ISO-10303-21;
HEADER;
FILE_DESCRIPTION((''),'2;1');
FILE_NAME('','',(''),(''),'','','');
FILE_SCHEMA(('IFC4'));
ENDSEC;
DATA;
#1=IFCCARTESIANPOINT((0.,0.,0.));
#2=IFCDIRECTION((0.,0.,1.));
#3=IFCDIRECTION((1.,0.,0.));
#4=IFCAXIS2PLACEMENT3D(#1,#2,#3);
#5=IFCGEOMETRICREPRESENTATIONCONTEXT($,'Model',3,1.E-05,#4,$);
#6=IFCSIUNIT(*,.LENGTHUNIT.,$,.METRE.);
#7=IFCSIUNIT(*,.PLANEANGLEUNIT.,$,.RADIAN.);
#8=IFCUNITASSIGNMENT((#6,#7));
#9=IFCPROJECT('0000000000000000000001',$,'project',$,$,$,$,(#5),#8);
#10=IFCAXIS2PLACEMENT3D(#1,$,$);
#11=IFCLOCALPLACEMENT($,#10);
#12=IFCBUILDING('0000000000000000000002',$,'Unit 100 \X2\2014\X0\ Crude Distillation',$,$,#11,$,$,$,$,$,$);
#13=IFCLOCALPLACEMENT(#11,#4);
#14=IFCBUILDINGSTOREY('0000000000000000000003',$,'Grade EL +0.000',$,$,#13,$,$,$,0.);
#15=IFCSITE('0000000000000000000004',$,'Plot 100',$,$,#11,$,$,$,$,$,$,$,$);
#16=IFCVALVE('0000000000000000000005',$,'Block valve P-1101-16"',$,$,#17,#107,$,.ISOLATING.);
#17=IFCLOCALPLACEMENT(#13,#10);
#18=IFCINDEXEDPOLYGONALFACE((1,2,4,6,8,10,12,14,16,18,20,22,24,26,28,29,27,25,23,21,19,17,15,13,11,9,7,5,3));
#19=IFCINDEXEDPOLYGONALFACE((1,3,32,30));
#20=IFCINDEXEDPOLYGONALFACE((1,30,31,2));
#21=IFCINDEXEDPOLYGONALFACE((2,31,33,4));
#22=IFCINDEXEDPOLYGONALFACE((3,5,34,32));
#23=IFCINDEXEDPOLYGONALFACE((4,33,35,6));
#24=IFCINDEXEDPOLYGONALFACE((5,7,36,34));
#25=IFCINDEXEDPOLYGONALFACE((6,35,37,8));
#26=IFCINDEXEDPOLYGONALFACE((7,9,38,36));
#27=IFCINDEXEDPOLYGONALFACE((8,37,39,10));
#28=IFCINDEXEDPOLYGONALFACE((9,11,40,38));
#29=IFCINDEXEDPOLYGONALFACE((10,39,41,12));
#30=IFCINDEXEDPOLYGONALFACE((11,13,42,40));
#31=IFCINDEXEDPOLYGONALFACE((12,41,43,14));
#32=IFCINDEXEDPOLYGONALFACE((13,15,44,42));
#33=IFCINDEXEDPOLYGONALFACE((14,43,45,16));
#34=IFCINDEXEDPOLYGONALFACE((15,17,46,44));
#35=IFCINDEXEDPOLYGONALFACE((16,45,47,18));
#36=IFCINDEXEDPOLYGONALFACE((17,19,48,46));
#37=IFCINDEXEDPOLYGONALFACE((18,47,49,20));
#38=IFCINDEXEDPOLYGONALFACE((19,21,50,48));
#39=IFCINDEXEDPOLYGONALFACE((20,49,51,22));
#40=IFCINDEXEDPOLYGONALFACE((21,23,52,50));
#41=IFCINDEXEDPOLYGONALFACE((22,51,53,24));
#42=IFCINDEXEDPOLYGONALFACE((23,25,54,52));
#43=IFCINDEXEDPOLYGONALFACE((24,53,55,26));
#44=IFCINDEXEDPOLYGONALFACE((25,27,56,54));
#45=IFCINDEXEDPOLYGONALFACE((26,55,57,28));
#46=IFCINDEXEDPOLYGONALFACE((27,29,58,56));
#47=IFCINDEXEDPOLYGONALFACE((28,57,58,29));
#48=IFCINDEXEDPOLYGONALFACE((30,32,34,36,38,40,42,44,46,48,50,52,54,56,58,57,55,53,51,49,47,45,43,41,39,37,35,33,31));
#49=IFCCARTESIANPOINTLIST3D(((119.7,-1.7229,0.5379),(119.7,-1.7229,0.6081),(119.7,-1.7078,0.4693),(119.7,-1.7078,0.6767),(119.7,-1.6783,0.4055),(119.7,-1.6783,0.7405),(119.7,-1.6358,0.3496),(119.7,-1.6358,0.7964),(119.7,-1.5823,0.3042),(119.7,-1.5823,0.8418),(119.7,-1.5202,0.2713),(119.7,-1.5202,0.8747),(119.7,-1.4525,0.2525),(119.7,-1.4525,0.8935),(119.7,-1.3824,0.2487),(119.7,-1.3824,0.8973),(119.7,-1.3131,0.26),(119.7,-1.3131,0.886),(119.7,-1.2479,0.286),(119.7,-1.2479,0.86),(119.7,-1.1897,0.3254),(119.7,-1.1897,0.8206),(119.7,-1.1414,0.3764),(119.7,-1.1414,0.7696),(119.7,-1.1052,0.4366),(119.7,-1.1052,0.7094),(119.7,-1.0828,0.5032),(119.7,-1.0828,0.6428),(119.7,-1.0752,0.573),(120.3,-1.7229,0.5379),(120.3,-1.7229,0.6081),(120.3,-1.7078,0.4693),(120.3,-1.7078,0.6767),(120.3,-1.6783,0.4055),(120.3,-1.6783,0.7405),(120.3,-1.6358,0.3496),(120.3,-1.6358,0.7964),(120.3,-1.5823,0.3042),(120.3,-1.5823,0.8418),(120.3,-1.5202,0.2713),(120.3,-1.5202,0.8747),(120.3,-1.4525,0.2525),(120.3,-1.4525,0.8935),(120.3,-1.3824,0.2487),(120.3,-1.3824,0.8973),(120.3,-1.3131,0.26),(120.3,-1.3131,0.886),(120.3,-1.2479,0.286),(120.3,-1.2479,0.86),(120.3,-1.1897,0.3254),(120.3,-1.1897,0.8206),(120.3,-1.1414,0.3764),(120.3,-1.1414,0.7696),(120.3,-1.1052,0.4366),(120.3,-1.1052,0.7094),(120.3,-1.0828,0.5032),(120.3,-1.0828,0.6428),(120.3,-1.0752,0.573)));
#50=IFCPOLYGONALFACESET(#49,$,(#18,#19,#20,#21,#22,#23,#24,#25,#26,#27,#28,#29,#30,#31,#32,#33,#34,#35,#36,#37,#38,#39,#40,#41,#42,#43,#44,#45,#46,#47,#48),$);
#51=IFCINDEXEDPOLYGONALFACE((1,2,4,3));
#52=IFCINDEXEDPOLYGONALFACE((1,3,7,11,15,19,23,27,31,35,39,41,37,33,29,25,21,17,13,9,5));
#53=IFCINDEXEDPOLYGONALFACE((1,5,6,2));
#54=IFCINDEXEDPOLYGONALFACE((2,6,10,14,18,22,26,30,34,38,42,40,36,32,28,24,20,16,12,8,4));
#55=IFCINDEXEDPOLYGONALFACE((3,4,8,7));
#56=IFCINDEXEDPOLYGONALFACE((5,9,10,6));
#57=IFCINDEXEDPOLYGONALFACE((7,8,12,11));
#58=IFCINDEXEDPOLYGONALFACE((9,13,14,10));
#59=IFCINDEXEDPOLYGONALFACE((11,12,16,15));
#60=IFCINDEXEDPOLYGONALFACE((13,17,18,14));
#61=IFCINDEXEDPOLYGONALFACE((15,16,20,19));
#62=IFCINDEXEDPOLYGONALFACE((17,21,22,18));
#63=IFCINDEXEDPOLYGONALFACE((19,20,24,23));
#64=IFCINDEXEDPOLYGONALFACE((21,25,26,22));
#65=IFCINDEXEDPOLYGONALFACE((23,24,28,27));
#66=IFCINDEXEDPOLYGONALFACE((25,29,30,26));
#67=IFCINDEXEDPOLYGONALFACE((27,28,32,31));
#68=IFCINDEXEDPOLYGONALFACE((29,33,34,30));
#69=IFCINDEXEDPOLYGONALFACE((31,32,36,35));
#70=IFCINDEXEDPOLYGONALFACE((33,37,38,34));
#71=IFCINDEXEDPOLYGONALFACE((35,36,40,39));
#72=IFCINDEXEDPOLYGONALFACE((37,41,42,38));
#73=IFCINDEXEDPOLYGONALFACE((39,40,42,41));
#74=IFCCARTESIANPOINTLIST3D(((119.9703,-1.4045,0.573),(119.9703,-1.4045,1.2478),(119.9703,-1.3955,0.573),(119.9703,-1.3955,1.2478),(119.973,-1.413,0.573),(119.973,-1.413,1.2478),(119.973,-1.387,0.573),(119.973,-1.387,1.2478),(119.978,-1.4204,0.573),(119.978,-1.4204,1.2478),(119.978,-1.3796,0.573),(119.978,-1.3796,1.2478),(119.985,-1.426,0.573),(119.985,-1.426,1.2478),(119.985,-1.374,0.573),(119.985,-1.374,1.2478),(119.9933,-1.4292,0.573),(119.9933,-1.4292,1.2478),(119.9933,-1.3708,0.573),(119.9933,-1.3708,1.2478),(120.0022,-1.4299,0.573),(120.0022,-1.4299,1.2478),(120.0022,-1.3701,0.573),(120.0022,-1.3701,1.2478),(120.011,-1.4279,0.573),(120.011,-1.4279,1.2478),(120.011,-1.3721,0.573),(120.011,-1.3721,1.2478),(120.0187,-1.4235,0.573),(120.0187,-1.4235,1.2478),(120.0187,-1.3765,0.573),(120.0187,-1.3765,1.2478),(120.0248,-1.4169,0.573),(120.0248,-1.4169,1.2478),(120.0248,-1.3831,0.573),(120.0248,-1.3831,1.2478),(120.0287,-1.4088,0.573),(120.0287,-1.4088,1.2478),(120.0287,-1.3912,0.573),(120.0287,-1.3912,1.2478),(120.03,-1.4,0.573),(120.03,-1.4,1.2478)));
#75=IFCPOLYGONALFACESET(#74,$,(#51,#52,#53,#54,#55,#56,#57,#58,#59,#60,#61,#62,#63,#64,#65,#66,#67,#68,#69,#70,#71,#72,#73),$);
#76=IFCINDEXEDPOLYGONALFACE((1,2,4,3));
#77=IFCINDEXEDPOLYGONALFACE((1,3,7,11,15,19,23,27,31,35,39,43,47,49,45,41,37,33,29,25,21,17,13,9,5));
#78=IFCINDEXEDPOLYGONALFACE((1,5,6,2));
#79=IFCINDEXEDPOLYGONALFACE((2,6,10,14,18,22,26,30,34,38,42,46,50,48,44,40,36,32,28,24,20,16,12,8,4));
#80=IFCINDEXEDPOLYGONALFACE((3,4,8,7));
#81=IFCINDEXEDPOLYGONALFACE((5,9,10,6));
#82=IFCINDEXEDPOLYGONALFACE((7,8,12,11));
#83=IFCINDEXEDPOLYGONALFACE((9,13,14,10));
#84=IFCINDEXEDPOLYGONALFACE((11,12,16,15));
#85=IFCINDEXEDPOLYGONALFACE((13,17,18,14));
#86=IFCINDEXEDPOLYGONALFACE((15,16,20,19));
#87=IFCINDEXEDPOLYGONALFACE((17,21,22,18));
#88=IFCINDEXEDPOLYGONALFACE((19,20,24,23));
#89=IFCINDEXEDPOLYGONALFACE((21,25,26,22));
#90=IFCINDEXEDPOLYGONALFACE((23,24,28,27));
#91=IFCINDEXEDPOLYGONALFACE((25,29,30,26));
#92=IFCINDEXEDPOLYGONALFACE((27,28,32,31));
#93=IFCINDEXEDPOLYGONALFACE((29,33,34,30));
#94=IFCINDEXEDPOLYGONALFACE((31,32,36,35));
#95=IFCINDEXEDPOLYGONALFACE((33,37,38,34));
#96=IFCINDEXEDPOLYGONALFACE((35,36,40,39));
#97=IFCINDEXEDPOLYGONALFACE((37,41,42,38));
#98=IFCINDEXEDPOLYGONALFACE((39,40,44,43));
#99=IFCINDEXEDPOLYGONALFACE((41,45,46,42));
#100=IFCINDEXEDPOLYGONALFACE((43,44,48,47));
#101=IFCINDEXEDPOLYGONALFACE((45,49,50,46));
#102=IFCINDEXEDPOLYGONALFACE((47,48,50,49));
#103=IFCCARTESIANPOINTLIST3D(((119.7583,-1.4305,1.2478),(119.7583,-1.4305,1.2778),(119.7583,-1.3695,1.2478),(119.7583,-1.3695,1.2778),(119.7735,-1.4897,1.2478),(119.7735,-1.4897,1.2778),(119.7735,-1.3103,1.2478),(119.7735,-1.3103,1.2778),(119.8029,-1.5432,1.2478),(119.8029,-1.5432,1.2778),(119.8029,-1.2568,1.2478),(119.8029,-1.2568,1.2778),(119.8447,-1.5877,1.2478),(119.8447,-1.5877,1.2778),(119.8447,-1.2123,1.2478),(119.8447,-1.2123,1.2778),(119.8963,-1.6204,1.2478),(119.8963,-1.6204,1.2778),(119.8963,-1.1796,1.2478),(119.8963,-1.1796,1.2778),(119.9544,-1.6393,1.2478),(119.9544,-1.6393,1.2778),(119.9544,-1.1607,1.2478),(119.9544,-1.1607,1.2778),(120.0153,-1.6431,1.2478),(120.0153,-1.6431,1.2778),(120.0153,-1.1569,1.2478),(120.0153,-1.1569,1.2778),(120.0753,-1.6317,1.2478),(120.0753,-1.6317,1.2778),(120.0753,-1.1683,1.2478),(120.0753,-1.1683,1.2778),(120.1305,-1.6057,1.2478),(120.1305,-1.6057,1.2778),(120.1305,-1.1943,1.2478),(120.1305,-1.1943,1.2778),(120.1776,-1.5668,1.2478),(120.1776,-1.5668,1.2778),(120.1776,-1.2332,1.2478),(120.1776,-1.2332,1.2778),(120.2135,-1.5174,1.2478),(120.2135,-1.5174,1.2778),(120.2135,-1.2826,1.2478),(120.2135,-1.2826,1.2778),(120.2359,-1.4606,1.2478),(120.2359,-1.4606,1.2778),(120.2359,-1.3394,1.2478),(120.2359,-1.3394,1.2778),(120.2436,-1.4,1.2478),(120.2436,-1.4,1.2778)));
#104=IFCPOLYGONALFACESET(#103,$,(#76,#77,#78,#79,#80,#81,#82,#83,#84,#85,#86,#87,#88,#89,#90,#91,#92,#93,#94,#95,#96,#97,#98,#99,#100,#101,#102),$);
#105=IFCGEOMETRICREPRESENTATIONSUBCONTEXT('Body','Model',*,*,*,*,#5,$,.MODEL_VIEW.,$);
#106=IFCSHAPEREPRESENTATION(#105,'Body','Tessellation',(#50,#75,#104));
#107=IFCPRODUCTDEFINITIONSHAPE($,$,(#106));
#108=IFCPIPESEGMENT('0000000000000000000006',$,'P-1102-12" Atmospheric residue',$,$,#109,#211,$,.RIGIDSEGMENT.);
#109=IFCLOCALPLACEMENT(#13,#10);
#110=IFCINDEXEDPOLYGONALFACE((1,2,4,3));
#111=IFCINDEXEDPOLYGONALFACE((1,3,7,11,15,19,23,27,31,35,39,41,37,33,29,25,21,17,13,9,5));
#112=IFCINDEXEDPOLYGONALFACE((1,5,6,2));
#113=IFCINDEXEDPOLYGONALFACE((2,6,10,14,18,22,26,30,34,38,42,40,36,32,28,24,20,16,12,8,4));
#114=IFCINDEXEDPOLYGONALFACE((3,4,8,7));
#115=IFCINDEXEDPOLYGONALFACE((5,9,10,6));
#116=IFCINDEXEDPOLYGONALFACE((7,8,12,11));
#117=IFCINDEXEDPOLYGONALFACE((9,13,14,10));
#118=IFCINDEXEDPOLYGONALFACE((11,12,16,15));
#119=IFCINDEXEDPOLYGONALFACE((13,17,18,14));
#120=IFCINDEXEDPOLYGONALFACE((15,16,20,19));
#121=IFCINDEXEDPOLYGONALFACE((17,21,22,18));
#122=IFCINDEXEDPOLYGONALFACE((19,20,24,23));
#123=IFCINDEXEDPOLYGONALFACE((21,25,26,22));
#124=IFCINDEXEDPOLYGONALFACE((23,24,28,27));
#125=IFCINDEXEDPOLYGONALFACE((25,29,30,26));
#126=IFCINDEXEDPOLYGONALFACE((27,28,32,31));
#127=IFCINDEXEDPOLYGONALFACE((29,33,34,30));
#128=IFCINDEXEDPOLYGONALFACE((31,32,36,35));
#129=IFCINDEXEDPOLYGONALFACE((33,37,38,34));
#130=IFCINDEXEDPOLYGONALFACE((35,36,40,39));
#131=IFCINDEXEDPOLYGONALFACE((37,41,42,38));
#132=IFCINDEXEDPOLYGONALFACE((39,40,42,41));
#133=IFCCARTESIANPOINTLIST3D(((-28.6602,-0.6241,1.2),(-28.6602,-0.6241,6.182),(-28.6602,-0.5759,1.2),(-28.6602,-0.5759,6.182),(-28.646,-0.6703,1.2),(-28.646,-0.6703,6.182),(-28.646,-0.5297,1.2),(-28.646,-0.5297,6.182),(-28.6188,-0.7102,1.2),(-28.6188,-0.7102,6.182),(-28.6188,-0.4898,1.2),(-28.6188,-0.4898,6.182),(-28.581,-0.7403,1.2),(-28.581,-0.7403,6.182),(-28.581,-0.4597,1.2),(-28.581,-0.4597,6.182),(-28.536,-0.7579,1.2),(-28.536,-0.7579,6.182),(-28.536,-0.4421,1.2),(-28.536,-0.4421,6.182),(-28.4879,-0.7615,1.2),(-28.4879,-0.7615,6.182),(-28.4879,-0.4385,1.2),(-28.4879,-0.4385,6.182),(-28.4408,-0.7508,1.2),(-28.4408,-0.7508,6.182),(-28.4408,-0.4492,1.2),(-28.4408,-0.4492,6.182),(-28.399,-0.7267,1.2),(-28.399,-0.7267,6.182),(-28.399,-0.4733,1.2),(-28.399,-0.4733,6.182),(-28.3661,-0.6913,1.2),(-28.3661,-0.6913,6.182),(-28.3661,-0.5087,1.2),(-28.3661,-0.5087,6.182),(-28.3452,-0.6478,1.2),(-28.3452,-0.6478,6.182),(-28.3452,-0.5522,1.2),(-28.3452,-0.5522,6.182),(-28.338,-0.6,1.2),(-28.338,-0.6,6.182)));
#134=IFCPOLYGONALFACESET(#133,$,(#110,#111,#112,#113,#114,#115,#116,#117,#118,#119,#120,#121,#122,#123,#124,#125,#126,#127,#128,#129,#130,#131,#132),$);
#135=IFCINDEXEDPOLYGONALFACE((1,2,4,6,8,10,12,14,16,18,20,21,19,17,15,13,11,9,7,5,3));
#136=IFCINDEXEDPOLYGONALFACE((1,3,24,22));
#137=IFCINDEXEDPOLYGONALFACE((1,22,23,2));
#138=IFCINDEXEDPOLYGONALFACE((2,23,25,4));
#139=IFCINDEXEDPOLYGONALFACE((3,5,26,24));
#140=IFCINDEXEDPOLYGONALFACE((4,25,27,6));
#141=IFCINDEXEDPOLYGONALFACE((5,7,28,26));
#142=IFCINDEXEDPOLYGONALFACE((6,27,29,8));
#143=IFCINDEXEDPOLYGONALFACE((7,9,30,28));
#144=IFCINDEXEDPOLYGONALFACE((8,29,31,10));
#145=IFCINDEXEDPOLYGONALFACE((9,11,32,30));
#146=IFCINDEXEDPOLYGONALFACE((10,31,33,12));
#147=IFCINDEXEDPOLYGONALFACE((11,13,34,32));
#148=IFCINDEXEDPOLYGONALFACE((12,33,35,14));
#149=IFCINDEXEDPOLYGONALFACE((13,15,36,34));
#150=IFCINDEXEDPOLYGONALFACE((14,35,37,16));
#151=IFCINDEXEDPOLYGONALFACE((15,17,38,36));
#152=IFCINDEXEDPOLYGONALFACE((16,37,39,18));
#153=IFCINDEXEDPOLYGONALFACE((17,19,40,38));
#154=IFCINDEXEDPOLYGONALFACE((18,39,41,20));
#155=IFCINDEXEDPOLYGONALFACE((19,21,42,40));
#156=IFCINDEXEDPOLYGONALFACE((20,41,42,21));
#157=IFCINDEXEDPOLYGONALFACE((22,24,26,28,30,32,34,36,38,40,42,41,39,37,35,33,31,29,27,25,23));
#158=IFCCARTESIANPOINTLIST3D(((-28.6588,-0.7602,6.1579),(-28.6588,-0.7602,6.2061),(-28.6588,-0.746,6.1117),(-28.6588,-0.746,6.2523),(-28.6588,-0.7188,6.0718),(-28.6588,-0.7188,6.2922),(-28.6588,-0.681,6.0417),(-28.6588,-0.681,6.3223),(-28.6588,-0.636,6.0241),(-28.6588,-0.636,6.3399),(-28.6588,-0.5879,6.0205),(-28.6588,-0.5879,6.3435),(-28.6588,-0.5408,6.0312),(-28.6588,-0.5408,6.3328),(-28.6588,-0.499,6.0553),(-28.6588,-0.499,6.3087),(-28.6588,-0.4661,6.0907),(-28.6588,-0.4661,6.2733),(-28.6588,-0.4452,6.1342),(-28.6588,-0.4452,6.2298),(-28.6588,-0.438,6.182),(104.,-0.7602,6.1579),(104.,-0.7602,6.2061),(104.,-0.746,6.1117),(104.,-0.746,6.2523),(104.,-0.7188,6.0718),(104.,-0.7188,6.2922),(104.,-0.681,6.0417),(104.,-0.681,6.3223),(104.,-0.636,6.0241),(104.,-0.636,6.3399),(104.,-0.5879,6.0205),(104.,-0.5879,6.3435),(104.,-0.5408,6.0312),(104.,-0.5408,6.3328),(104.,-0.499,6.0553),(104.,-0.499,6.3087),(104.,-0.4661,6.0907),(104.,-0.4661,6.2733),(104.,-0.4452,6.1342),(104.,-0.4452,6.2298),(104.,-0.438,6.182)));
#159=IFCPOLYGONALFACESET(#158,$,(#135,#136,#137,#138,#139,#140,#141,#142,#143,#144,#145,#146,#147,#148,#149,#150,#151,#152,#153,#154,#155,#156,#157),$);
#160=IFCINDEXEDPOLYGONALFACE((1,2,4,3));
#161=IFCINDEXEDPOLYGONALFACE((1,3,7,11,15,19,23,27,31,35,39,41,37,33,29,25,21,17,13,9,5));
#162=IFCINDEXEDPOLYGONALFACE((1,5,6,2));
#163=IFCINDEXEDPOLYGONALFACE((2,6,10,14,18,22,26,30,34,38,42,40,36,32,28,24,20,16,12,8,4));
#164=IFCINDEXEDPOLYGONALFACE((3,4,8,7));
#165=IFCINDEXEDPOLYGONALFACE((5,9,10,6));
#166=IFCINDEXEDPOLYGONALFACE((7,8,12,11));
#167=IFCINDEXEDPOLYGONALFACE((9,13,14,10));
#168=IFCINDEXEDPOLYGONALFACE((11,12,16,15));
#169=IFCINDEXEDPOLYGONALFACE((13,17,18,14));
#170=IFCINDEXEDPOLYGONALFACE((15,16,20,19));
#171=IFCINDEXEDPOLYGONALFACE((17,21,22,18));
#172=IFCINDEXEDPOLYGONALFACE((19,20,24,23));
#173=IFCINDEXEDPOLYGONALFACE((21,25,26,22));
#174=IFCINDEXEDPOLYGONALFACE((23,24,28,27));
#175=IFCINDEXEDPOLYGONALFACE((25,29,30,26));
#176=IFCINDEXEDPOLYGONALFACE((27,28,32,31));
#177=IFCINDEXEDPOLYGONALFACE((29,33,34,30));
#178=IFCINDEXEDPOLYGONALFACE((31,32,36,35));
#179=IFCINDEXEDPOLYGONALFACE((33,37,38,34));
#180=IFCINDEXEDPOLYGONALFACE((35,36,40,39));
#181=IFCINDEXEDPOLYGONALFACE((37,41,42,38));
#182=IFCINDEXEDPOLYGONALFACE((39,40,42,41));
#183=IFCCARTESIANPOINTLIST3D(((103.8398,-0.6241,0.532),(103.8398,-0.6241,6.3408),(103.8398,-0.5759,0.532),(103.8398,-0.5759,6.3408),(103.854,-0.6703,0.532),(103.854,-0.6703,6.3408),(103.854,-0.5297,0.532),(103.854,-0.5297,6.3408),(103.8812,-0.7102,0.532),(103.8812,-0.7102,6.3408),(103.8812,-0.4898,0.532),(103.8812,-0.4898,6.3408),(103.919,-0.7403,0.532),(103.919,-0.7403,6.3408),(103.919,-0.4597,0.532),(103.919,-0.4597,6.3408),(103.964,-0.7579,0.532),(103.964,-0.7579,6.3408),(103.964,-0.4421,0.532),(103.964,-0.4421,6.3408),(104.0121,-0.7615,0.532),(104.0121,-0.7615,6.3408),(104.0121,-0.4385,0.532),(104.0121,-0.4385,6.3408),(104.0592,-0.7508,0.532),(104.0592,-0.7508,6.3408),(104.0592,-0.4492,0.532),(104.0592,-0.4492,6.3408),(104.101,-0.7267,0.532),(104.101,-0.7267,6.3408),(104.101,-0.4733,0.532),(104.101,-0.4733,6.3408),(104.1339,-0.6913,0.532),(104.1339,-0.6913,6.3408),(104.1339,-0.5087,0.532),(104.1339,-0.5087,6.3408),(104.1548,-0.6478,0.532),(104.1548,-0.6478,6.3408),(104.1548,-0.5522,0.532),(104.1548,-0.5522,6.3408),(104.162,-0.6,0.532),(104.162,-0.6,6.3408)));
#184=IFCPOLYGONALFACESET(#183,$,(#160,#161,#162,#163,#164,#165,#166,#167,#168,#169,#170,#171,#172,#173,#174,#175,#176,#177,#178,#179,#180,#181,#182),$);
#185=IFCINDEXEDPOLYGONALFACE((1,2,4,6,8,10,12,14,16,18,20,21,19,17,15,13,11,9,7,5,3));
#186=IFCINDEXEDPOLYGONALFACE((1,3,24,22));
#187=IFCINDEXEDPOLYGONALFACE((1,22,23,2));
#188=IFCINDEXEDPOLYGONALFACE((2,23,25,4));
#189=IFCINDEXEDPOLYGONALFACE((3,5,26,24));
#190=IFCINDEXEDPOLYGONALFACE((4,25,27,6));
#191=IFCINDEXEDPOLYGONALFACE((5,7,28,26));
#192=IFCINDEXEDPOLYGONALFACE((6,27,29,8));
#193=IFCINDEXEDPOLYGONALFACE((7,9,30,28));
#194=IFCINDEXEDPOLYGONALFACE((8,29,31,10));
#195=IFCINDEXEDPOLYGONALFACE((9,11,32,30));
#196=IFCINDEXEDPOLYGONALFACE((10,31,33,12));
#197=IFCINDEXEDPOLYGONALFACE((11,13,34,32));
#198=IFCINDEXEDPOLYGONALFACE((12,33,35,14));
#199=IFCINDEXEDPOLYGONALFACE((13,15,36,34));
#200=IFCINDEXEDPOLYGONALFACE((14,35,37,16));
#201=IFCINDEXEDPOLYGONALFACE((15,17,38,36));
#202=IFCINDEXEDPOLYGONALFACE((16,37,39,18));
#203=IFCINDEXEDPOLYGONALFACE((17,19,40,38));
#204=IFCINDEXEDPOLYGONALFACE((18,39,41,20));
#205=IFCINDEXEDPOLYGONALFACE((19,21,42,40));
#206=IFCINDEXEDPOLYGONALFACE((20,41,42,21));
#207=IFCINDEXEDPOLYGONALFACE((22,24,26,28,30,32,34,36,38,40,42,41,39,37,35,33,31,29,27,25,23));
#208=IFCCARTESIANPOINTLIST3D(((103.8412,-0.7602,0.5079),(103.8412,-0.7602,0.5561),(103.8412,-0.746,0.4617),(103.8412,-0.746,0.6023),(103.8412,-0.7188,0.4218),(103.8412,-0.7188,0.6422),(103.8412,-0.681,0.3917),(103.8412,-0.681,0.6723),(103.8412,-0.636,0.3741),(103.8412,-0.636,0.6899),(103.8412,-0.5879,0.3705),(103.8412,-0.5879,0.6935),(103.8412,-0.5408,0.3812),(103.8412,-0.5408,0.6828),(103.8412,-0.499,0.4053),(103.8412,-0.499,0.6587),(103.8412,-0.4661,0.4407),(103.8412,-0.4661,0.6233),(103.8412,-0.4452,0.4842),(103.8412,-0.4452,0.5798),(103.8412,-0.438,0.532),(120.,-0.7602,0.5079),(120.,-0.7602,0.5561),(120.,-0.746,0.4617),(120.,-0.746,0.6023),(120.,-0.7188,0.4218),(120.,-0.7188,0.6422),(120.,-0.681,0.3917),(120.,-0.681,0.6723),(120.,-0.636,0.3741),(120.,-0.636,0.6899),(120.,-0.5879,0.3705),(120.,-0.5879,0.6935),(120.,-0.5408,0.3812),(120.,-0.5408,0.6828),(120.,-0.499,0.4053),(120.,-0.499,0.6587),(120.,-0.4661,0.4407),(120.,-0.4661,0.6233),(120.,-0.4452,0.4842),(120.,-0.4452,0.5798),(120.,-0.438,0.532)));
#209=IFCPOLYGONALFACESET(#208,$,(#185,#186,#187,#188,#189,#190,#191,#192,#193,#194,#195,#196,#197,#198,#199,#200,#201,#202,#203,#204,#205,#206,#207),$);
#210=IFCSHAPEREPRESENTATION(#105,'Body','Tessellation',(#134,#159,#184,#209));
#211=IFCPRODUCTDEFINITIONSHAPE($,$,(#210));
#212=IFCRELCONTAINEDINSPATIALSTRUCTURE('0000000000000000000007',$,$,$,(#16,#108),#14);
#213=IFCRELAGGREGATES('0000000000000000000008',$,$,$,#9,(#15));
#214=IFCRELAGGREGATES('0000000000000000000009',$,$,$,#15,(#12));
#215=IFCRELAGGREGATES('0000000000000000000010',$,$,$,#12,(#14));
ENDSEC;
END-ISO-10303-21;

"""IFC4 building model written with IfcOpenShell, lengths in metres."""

from ifc_helpers import new_model, si_unit, frame, origin, origin_with_axes, origin_2d, place, context, subcontext, project, spatial, circle, extrude, element, save


model = new_model("IFC4")

# Units and contexts
model_context = context("Model", 3, precision=1e-05, world=origin_with_axes())
body_context = subcontext(model_context, "Body", "Model", "MODEL_VIEW")
ifc_project = project(units=[si_unit("LENGTHUNIT", "METRE"), si_unit("PLANEANGLEUNIT", "RADIAN")], contexts=[model_context])

# Site, building, storey
placement = place(None, origin())
site = spatial("IfcSite", under=ifc_project, at=placement, Name="Plot 100")
building = spatial("IfcBuilding", under=site, at=placement, Name="Unit 100 — Crude Distillation")
storey_placement = place(placement, origin_with_axes())
storey = spatial("IfcBuildingStorey", under=building, at=storey_placement, Name="Grade EL +0.000", Elevation=0.0)

# Valve
valve_1_placement = place(storey_placement, origin_with_axes())
element("IfcValve", 1, at=valve_1_placement, inside=storey, Name="Block valve P-1101-16\"", PredefinedType="ISOLATING", context=body_context, shape_type="SweptSolid", body=[
    extrude(circle(Radius=0.3248, at=origin_2d()), frame((119.7, -1.4, 0.573), z_axis=(1.0, 0.0, 0.0), x_axis=(0.0, 1.0, 0.0)), (0.0, 0.0, 1.0), 0.6),
    extrude(circle(Radius=0.03, at=origin_2d()), frame((120.0, -1.4, 0.573), z_axis=(0.0, 0.0, 1.0), x_axis=(1.0, 0.0, 0.0)), (0.0, 0.0, 1.0), 0.6748),
    extrude(circle(Radius=0.2436, at=origin_2d()), frame((120.0, -1.4, 1.2478), z_axis=(0.0, 0.0, 1.0), x_axis=(1.0, 0.0, 0.0)), (0.0, 0.0, 1.0), 0.03),
])

# Pipe segment
pipe_segment_1_placement = place(storey_placement, origin_with_axes())
element("IfcPipeSegment", 2, at=pipe_segment_1_placement, inside=storey, Name="P-1102-12\" Atmospheric residue", PredefinedType="RIGIDSEGMENT", context=body_context, shape_type="SweptSolid", body=[
    extrude(circle(Radius=0.162, at=origin_2d()), frame((-28.5, -0.6, 1.2), z_axis=(0.0, 0.0, 1.0), x_axis=(1.0, 0.0, 0.0)), (0.0, 0.0, 1.0), 4.982),
    extrude(circle(Radius=0.162, at=origin_2d()), frame((-28.6588, -0.6, 6.182), z_axis=(1.0, 0.0, 0.0), x_axis=(0.0, 1.0, 0.0)), (0.0, 0.0, 1.0), 132.6588),
    extrude(circle(Radius=0.162, at=origin_2d()), frame((104.0, -0.6, 6.3408), z_axis=(0.0, 0.0, -1.0), x_axis=(1.0, 0.0, 0.0)), (0.0, 0.0, 1.0), 5.8088),
    extrude(circle(Radius=0.162, at=origin_2d()), frame((103.8412, -0.6, 0.532), z_axis=(1.0, 0.0, 0.0), x_axis=(0.0, 1.0, 0.0)), (0.0, 0.0, 1.0), 16.1588),
])

save(model, "model.ifc")
